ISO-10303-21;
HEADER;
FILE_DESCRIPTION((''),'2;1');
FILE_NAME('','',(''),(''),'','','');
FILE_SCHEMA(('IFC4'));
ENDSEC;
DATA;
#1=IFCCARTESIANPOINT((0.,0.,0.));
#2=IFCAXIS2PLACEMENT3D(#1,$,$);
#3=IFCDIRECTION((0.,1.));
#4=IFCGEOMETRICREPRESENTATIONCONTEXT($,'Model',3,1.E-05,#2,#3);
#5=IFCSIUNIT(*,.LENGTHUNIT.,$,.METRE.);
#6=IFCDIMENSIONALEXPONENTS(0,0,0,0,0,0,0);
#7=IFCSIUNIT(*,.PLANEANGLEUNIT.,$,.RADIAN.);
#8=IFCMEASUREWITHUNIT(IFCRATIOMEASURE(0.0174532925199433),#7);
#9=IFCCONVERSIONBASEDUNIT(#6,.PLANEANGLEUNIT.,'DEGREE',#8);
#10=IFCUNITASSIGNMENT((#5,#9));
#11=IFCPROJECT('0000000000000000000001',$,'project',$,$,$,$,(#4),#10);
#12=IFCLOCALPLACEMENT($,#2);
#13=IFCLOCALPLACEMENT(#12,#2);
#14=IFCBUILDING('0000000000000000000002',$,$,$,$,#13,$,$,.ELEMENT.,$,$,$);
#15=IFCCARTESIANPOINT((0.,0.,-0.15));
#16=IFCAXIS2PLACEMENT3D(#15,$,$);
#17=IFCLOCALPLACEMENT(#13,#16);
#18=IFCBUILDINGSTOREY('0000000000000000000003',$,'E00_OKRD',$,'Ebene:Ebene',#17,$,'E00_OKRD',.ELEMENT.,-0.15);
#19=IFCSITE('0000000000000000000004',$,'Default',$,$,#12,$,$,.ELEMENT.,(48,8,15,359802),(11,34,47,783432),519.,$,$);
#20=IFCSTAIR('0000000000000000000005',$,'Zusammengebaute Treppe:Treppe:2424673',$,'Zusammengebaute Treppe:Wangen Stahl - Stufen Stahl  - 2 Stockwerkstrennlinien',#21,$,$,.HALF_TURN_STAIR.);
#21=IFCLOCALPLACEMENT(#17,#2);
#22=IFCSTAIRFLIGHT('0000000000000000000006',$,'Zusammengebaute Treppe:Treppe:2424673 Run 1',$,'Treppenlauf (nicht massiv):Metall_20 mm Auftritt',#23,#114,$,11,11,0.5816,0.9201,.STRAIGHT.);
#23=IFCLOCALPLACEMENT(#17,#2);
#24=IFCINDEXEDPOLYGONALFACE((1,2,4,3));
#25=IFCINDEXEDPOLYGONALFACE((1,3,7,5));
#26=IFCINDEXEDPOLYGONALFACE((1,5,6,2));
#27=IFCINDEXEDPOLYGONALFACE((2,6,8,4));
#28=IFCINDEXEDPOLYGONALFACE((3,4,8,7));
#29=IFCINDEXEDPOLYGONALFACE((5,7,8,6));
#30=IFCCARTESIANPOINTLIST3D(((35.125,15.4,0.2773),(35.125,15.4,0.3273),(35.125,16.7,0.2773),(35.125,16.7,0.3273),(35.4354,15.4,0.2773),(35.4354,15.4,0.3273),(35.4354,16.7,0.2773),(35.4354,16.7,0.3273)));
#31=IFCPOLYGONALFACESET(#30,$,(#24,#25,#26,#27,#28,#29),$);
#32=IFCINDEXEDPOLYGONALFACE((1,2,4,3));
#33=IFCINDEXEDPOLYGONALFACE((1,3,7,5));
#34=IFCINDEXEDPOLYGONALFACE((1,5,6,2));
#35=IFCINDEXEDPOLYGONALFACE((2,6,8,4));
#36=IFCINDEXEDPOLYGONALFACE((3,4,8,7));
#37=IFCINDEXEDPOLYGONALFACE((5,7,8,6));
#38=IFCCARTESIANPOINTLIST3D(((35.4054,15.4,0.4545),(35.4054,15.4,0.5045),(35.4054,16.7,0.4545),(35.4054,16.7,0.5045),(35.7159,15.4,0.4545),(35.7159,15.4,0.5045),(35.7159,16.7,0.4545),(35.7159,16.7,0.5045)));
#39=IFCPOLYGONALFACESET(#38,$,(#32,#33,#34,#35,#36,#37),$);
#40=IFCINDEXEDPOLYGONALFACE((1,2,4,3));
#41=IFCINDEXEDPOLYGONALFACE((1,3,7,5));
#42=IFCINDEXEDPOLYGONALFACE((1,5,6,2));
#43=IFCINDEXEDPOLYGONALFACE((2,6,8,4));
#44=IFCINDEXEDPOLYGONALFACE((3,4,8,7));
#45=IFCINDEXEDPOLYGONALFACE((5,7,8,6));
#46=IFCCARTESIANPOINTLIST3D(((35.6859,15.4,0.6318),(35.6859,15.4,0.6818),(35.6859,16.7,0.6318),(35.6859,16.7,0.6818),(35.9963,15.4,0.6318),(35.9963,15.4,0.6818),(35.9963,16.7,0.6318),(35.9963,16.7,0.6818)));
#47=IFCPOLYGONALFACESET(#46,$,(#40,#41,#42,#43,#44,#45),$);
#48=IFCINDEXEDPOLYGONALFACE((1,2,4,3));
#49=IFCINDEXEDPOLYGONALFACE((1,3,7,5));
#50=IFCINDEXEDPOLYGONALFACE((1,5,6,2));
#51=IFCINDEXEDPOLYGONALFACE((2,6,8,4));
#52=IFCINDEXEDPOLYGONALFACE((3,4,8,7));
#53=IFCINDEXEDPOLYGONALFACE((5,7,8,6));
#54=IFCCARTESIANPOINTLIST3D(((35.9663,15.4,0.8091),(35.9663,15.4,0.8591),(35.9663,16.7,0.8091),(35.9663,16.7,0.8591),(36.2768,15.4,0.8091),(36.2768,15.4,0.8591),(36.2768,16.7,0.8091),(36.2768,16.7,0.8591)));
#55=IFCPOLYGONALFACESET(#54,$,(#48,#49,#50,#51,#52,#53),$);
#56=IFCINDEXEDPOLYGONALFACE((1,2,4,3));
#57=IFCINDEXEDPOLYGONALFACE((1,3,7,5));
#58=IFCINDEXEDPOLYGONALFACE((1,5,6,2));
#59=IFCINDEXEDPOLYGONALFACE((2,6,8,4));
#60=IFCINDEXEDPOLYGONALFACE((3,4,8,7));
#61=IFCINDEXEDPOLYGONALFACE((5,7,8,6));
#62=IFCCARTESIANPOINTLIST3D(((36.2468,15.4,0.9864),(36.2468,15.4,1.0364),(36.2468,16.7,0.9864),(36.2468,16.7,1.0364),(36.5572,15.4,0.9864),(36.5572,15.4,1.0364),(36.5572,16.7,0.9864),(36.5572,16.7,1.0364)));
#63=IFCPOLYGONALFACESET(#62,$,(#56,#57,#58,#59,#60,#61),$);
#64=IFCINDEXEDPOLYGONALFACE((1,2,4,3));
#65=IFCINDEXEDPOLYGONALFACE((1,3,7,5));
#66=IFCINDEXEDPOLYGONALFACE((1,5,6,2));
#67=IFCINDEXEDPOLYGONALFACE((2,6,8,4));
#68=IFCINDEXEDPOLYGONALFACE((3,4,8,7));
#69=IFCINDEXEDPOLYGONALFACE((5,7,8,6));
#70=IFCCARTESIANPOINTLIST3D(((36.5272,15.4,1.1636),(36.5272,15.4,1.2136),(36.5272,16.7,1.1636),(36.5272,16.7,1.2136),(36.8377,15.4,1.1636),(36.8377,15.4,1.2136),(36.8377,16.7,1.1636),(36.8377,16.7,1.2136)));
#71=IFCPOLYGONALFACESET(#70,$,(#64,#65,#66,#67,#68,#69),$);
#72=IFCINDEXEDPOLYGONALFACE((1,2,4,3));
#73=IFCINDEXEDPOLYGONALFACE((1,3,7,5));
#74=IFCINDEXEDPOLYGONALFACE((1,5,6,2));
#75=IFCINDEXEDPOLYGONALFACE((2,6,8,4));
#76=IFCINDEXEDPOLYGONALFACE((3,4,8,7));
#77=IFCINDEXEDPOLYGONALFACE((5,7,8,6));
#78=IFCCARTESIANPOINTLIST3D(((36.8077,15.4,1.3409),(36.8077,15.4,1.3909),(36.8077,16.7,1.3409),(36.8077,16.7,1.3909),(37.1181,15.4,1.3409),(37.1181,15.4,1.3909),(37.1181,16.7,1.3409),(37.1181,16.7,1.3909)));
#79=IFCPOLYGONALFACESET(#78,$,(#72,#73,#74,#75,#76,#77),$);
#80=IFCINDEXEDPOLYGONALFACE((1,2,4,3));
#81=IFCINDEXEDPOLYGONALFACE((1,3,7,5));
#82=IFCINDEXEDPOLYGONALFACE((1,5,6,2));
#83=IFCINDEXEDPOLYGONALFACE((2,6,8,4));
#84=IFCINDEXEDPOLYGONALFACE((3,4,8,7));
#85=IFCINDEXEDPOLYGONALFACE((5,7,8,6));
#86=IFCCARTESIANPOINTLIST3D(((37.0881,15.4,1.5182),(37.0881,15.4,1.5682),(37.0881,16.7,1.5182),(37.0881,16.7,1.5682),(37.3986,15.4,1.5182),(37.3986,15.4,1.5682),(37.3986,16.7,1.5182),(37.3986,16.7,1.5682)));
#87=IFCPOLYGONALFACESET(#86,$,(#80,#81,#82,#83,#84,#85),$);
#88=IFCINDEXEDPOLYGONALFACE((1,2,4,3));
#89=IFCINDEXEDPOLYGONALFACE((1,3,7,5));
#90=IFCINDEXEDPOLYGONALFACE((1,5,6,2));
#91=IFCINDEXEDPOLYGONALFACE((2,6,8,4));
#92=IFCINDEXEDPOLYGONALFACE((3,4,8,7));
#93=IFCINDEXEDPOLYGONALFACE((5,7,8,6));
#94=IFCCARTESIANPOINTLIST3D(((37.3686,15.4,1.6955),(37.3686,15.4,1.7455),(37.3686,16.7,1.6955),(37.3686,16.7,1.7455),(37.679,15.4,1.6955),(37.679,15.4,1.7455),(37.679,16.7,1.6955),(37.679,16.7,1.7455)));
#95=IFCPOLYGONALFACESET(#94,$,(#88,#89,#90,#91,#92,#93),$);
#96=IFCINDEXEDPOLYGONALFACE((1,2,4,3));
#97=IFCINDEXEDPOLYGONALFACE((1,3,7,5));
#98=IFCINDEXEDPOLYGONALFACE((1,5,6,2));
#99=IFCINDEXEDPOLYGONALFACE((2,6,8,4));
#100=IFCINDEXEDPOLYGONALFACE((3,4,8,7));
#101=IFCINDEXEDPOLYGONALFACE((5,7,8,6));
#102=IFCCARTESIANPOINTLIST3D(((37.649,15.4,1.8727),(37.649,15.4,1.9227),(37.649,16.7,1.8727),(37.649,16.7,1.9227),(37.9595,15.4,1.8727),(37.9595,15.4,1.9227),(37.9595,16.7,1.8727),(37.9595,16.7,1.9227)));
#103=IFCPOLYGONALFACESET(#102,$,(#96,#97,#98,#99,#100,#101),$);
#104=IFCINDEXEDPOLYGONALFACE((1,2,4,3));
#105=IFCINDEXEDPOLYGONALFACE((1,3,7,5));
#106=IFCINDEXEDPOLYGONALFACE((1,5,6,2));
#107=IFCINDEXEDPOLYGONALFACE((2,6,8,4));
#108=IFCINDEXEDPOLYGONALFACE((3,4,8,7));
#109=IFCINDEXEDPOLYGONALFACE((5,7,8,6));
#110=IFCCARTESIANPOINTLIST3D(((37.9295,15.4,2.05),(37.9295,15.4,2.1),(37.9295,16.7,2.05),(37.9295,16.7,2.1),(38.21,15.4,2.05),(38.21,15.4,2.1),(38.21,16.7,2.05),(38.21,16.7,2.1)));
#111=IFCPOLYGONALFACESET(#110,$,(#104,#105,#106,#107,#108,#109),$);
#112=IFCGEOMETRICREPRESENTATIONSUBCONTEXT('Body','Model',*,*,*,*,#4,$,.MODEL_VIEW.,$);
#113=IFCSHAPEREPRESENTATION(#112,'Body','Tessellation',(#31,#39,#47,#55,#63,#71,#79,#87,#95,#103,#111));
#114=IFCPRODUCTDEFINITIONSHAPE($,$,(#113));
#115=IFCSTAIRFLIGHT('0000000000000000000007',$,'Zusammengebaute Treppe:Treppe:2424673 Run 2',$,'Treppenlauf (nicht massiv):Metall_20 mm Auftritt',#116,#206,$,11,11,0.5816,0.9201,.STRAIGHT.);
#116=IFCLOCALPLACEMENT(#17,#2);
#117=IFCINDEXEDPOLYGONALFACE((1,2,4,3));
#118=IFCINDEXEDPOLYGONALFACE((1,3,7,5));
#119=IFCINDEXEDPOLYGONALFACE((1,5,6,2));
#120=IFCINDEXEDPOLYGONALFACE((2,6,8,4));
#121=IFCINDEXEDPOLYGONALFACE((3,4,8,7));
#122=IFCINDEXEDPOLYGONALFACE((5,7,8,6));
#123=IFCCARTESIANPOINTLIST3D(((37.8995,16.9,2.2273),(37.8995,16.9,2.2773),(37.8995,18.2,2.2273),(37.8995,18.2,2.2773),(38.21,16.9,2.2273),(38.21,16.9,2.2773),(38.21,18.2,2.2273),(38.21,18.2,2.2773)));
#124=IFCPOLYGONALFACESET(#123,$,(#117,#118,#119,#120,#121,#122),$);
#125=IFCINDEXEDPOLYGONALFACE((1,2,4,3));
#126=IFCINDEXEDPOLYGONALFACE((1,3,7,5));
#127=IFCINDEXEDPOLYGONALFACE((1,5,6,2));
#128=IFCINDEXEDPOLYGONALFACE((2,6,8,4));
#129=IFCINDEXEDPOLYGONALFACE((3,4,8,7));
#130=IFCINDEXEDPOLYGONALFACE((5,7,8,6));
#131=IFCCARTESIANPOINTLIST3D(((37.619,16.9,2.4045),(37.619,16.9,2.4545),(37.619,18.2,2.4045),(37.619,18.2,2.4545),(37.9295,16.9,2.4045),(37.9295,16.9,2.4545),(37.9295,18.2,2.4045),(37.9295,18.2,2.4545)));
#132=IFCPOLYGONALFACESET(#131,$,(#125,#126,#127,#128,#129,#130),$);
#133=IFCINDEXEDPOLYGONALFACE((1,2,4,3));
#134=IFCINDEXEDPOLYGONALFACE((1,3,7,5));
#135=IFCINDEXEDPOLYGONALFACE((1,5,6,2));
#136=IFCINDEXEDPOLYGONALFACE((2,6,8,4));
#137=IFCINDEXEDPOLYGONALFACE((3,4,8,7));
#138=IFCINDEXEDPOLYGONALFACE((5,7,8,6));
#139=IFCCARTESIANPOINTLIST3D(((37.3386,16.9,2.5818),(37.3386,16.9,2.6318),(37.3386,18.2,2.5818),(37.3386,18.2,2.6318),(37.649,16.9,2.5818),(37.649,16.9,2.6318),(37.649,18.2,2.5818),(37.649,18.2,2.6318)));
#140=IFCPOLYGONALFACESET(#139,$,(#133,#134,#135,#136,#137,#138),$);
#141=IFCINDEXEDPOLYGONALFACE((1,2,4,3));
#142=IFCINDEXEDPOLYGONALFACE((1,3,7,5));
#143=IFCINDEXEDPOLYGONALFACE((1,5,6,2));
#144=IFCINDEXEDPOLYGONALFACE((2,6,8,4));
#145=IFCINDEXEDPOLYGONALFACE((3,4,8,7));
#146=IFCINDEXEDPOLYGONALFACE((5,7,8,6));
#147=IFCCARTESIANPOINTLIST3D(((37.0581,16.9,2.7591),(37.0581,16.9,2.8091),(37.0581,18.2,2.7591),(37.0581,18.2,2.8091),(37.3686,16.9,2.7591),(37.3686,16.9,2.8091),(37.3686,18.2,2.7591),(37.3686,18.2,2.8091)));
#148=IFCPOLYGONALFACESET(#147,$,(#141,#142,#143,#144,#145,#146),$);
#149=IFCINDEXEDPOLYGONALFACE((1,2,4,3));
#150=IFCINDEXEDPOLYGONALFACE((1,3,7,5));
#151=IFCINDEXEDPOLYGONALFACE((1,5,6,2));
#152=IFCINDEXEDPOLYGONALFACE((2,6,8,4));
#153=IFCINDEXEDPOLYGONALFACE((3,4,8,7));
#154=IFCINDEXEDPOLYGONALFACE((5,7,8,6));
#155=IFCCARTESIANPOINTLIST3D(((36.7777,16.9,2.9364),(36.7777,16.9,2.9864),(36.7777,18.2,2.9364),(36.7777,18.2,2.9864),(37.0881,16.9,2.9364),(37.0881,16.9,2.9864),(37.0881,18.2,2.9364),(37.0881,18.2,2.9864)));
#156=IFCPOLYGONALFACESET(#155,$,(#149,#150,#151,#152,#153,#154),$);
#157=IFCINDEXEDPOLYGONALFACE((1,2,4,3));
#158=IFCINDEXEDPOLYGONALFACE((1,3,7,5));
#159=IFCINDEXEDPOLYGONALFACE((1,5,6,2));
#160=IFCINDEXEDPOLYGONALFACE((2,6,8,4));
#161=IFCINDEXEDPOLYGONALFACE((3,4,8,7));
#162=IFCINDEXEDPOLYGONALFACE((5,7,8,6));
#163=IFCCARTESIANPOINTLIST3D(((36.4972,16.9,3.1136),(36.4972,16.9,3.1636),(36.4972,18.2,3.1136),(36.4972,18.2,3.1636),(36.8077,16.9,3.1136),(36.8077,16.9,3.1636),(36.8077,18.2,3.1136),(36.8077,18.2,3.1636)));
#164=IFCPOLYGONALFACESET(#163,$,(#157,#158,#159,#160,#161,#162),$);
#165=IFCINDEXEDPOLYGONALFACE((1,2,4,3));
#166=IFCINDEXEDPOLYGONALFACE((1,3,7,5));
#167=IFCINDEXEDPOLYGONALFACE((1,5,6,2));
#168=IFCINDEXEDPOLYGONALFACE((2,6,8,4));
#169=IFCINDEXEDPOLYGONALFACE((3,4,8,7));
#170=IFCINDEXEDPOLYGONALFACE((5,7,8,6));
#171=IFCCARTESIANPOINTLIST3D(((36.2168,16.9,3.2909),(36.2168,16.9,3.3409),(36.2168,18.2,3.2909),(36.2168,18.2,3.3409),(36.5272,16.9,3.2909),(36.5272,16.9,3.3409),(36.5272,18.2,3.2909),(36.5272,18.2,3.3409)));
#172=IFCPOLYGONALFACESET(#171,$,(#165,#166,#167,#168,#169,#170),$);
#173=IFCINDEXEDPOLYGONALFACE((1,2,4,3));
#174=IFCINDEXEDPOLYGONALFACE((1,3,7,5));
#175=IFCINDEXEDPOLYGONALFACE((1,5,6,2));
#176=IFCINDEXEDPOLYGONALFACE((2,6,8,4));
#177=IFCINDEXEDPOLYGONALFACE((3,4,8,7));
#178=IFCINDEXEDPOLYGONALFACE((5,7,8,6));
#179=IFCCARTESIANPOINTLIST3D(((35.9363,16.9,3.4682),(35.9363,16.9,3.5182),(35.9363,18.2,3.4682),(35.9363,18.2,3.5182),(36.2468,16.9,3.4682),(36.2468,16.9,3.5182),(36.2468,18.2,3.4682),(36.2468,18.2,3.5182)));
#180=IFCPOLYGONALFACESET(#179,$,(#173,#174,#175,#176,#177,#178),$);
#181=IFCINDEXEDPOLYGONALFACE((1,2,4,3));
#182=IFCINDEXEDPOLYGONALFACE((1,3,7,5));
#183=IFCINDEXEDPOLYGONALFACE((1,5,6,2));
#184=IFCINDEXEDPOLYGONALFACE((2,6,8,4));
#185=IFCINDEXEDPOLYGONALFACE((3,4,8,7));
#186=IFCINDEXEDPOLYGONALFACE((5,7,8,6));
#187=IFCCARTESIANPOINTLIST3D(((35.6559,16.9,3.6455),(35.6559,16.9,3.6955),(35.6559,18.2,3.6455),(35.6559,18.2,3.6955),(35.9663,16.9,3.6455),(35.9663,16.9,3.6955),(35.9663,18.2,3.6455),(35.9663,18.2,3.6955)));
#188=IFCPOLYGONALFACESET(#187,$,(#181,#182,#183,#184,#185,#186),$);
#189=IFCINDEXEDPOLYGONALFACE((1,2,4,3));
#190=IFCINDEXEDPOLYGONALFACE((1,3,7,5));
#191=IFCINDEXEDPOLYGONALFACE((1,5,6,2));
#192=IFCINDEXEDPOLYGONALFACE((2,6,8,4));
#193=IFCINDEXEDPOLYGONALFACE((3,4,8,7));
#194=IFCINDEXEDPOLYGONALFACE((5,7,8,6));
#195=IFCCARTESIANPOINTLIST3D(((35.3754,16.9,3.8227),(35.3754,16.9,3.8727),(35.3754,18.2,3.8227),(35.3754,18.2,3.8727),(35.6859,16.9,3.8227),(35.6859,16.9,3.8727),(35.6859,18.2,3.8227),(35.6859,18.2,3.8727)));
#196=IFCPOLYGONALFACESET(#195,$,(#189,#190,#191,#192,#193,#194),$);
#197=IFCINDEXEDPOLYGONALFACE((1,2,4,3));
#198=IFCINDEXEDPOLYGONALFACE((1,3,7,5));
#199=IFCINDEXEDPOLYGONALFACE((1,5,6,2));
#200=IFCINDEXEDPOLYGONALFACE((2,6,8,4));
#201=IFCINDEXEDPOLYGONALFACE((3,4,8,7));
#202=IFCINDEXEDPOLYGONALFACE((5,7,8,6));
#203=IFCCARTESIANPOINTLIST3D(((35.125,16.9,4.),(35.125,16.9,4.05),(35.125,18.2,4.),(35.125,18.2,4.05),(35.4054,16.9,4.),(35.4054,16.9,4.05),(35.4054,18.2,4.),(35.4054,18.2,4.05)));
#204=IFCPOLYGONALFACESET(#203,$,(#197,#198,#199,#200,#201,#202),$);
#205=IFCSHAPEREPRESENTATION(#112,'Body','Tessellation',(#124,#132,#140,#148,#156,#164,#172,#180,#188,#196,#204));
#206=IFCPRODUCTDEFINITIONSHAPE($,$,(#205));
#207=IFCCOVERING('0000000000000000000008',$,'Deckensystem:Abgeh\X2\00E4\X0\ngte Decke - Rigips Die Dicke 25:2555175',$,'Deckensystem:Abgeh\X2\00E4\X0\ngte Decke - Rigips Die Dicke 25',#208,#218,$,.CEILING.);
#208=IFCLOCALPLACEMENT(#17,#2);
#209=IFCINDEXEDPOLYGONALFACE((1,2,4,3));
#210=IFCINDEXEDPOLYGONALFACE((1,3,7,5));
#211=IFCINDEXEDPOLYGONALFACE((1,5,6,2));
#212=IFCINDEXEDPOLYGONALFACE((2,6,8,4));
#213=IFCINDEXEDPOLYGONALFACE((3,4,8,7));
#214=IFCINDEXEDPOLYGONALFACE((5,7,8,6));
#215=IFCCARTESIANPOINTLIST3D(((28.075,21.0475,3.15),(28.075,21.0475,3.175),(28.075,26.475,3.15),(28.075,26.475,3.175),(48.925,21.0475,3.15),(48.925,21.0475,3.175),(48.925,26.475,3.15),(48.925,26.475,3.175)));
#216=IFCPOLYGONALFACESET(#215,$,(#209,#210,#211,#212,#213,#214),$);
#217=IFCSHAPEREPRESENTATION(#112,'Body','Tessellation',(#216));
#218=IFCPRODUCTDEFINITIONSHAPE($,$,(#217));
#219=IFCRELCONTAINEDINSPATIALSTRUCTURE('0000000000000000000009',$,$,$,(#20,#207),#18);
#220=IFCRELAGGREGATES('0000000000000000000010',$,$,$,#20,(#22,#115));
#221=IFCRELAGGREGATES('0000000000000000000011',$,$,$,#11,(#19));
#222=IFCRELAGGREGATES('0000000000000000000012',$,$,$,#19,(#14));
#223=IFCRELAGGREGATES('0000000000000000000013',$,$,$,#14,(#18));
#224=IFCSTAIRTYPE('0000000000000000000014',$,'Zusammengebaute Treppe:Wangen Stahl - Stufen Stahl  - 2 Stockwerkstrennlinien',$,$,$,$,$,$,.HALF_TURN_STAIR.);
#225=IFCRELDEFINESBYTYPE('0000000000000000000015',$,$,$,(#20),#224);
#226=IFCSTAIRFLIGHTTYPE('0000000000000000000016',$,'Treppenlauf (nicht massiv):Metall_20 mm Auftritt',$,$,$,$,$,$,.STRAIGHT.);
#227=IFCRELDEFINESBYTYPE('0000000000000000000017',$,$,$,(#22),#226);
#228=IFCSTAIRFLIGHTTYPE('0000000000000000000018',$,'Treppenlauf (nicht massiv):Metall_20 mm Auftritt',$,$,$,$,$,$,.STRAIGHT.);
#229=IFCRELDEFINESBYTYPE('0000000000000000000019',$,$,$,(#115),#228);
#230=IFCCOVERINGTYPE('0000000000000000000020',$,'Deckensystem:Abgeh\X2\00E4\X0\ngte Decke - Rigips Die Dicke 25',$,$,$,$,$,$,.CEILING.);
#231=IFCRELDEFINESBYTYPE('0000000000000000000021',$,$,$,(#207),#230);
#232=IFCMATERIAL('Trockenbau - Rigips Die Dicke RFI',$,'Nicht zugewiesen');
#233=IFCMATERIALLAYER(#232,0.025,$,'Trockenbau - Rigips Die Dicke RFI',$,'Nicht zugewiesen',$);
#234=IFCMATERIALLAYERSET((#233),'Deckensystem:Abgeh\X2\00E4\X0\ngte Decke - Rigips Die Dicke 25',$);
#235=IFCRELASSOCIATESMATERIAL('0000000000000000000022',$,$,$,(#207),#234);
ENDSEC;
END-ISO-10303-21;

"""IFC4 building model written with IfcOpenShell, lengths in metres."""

from ifc_helpers import new_model, entity, si_unit, converted_unit, direction, frame, frame_2d, origin, origin_2d_with_axis, place, context, subcontext, project, spatial, rectangle, extrude, material, layer, layer_set, layer_usage, type_object, element, aggregate, save


model = new_model("IFC4")

# Units and contexts
model_context = context("Model", 3, precision=1e-05, world=origin(), true_north=direction((0.0, 1.0)))
body_context = subcontext(model_context, "Body", "Model", "MODEL_VIEW")
ifc_project = project(units=[si_unit("LENGTHUNIT", "METRE"), converted_unit("PLANEANGLEUNIT", "DEGREE", entity("IfcRatioMeasure", 0.0174532925199433), si_unit("PLANEANGLEUNIT", "RADIAN"), dimensions=[0, 0, 0, 0, 0, 0, 0])], contexts=[model_context])

# Site, building, storey
site_placement = place(None, frame((0.0, 0.0, 0.0)))
site = spatial("IfcSite", under=ifc_project, at=site_placement, Name="Default", CompositionType="ELEMENT", RefLatitude=(48, 8, 15, 359802), RefLongitude=(11, 34, 47, 783432), RefElevation=519.0)
building_placement = place(site_placement, origin())
building = spatial("IfcBuilding", under=site, at=building_placement, CompositionType="ELEMENT")
storey_placement = place(building_placement, frame((0.0, 0.0, -0.15)))
storey = spatial("IfcBuildingStorey", under=building, at=storey_placement, Name="E00_OKRD", ObjectType="Ebene:Ebene", LongName="E00_OKRD", CompositionType="ELEMENT", Elevation=-0.15)

# Stair
stair_type = type_object("IfcStairType", Name="Zusammengebaute Treppe:Wangen Stahl - Stufen Stahl  - 2 Stockwerkstrennlinien", PredefinedType="HALF_TURN_STAIR")
stair_placement = place(storey_placement, origin())
stair = element("IfcStair", 1, at=stair_placement, inside=storey, type_object=stair_type, Name="Zusammengebaute Treppe:Treppe:2424673", ObjectType="Zusammengebaute Treppe:Wangen Stahl - Stufen Stahl  - 2 Stockwerkstrennlinien", PredefinedType="HALF_TURN_STAIR")

# Stair flights
stair_flight_type_1 = type_object("IfcStairFlightType", Name="Treppenlauf (nicht massiv):Metall_20 mm Auftritt", PredefinedType="STRAIGHT")
stair_flight_1_placement = place(stair_placement, frame((35.125, 15.4, 0.0)))
stair_flight_1 = element("IfcStairFlight", 2, at=stair_flight_1_placement, type_object=stair_flight_type_1, Name="Zusammengebaute Treppe:Treppe:2424673 Run 1", ObjectType="Treppenlauf (nicht massiv):Metall_20 mm Auftritt", NumberOfRisers=11, NumberOfTreads=11, PredefinedType="STRAIGHT", RiserHeight=0.5816, TreadLength=0.9201, context=body_context, shape_type="SweptSolid", body=[
    extrude(rectangle(XDim=0.3105, YDim=1.3, at=frame_2d((0.0, 0.0), x_axis=(1.0, 0.0))), frame((0.1552, 0.65, 0.2773), z_axis=(0.0, 0.0, 1.0), x_axis=(-1.0, 0.0, 0.0)), (0.0, 0.0, 1.0), 0.05),
    extrude(rectangle(XDim=0.3105, YDim=1.3, at=frame_2d((0.0, 0.0), x_axis=(1.0, 0.0))), frame((0.4357, 0.65, 0.4545), z_axis=(0.0, 0.0, 1.0), x_axis=(-1.0, 0.0, 0.0)), (0.0, 0.0, 1.0), 0.05),
    extrude(rectangle(XDim=0.3105, YDim=1.3, at=frame_2d((0.0, 0.0), x_axis=(1.0, 0.0))), frame((0.7161, 0.65, 0.6318), z_axis=(0.0, 0.0, 1.0), x_axis=(-1.0, 0.0, 0.0)), (0.0, 0.0, 1.0), 0.05),
    extrude(rectangle(XDim=0.3105, YDim=1.3, at=frame_2d((0.0, 0.0), x_axis=(1.0, 0.0))), frame((0.9966, 0.65, 0.8091), z_axis=(0.0, 0.0, 1.0), x_axis=(-1.0, 0.0, 0.0)), (0.0, 0.0, 1.0), 0.05),
    extrude(rectangle(XDim=0.3105, YDim=1.3, at=frame_2d((0.0, 0.0), x_axis=(1.0, 0.0))), frame((1.277, 0.65, 0.9864), z_axis=(0.0, 0.0, 1.0), x_axis=(-1.0, 0.0, 0.0)), (0.0, 0.0, 1.0), 0.05),
    extrude(rectangle(XDim=0.3105, YDim=1.3, at=frame_2d((0.0, 0.0), x_axis=(1.0, 0.0))), frame((1.5575, 0.65, 1.1636), z_axis=(0.0, 0.0, 1.0), x_axis=(-1.0, 0.0, 0.0)), (0.0, 0.0, 1.0), 0.05),
    extrude(rectangle(XDim=0.3105, YDim=1.3, at=frame_2d((0.0, 0.0), x_axis=(1.0, 0.0))), frame((1.838, 0.65, 1.3409), z_axis=(0.0, 0.0, 1.0), x_axis=(-1.0, 0.0, 0.0)), (0.0, 0.0, 1.0), 0.05),
    extrude(rectangle(XDim=0.3105, YDim=1.3, at=frame_2d((0.0, 0.0), x_axis=(1.0, 0.0))), frame((2.1184, 0.65, 1.5182), z_axis=(0.0, 0.0, 1.0), x_axis=(-1.0, 0.0, 0.0)), (0.0, 0.0, 1.0), 0.05),
    extrude(rectangle(XDim=0.3105, YDim=1.3, at=frame_2d((0.0, 0.0), x_axis=(1.0, 0.0))), frame((2.3989, 0.65, 1.6955), z_axis=(0.0, 0.0, 1.0), x_axis=(-1.0, 0.0, 0.0)), (0.0, 0.0, 1.0), 0.05),
    extrude(rectangle(XDim=0.3105, YDim=1.3, at=frame_2d((0.0, 0.0), x_axis=(1.0, 0.0))), frame((2.6793, 0.65, 1.8727), z_axis=(0.0, 0.0, 1.0), x_axis=(-1.0, 0.0, 0.0)), (0.0, 0.0, 1.0), 0.05),
    extrude(rectangle(XDim=0.2805, YDim=1.3, at=frame_2d((0.0, 0.0), x_axis=(1.0, 0.0))), frame((2.9448, 0.65, 2.05), z_axis=(0.0, 0.0, 1.0), x_axis=(-1.0, 0.0, 0.0)), (0.0, 0.0, 1.0), 0.05),
])
stair_flight_type_2 = type_object("IfcStairFlightType", Name="Treppenlauf (nicht massiv):Metall_20 mm Auftritt", PredefinedType="STRAIGHT")
stair_flight_2_placement = place(stair_placement, frame((35.125, 16.9, 0.0)))
stair_flight_2 = element("IfcStairFlight", 3, at=stair_flight_2_placement, type_object=stair_flight_type_2, Name="Zusammengebaute Treppe:Treppe:2424673 Run 2", ObjectType="Treppenlauf (nicht massiv):Metall_20 mm Auftritt", NumberOfRisers=11, NumberOfTreads=11, PredefinedType="STRAIGHT", RiserHeight=0.5816, TreadLength=0.9201, context=body_context, shape_type="SweptSolid", body=[
    extrude(rectangle(XDim=0.3105, YDim=1.3, at=frame_2d((0.0, 0.0), x_axis=(1.0, 0.0))), frame((2.9298, 0.65, 2.2273)), (0.0, 0.0, 1.0), 0.05),
    extrude(rectangle(XDim=0.3105, YDim=1.3, at=frame_2d((0.0, 0.0), x_axis=(1.0, 0.0))), frame((2.6493, 0.65, 2.4045)), (0.0, 0.0, 1.0), 0.05),
    extrude(rectangle(XDim=0.3105, YDim=1.3, at=frame_2d((0.0, 0.0), x_axis=(1.0, 0.0))), frame((2.3689, 0.65, 2.5818)), (0.0, 0.0, 1.0), 0.05),
    extrude(rectangle(XDim=0.3105, YDim=1.3, at=frame_2d((0.0, 0.0), x_axis=(1.0, 0.0))), frame((2.0884, 0.65, 2.7591)), (0.0, 0.0, 1.0), 0.05),
    extrude(rectangle(XDim=0.3105, YDim=1.3, at=frame_2d((0.0, 0.0), x_axis=(1.0, 0.0))), frame((1.808, 0.65, 2.9364)), (0.0, 0.0, 1.0), 0.05),
    extrude(rectangle(XDim=0.3105, YDim=1.3, at=frame_2d((0.0, 0.0), x_axis=(1.0, 0.0))), frame((1.5275, 0.65, 3.1136)), (0.0, 0.0, 1.0), 0.05),
    extrude(rectangle(XDim=0.3105, YDim=1.3, at=frame_2d((0.0, 0.0), x_axis=(1.0, 0.0))), frame((1.247, 0.65, 3.2909)), (0.0, 0.0, 1.0), 0.05),
    extrude(rectangle(XDim=0.3105, YDim=1.3, at=frame_2d((0.0, 0.0), x_axis=(1.0, 0.0))), frame((0.9666, 0.65, 3.4682)), (0.0, 0.0, 1.0), 0.05),
    extrude(rectangle(XDim=0.3105, YDim=1.3, at=frame_2d((0.0, 0.0), x_axis=(1.0, 0.0))), frame((0.6861, 0.65, 3.6455)), (0.0, 0.0, 1.0), 0.05),
    extrude(rectangle(XDim=0.3105, YDim=1.3, at=frame_2d((0.0, 0.0), x_axis=(1.0, 0.0))), frame((0.4057, 0.65, 3.8227)), (0.0, 0.0, 1.0), 0.05),
    extrude(rectangle(XDim=0.2805, YDim=1.3, at=frame_2d((0.0, 0.0), x_axis=(1.0, 0.0))), frame((0.1402, 0.65, 4.0)), (0.0, 0.0, 1.0), 0.05),
])
aggregate(stair, [stair_flight_1, stair_flight_2])

# Covering
ifc_material_1 = material(Name="Trockenbau - Rigips Die Dicke RFI", Category="Nicht zugewiesen")
ifc_layer_1 = layer(ifc_material_1, 0.025, Name="Trockenbau - Rigips Die Dicke RFI", Category="Nicht zugewiesen")
ifc_layer_set_1 = layer_set([ifc_layer_1], Name="Deckensystem:Abgehängte Decke - Rigips Die Dicke 25")
ifc_layer_usage_1 = layer_usage(ifc_layer_set_1, "AXIS3", "POSITIVE", 0.0)
covering_type = type_object("IfcCoveringType", Name="Deckensystem:Abgehängte Decke - Rigips Die Dicke 25", PredefinedType="CEILING")
covering_placement = place(storey_placement, frame((28.075, 21.0475, 3.15)))
element("IfcCovering", 4, at=covering_placement, inside=storey, type_object=covering_type, material=ifc_layer_usage_1, Name="Deckensystem:Abgehängte Decke - Rigips Die Dicke 25:2555175", ObjectType="Deckensystem:Abgehängte Decke - Rigips Die Dicke 25", PredefinedType="CEILING", context=body_context, shape_type="SweptSolid", body=[
    extrude(rectangle(XDim=20.85, YDim=5.4275, at=origin_2d_with_axis()), frame((10.425, 2.7137, 0.0), z_axis=(0.0, 0.0, 1.0), x_axis=(-1.0, 0.0, 0.0)), (0.0, 0.0, 1.0), 0.025),
])

save(model, "model.ifc")
